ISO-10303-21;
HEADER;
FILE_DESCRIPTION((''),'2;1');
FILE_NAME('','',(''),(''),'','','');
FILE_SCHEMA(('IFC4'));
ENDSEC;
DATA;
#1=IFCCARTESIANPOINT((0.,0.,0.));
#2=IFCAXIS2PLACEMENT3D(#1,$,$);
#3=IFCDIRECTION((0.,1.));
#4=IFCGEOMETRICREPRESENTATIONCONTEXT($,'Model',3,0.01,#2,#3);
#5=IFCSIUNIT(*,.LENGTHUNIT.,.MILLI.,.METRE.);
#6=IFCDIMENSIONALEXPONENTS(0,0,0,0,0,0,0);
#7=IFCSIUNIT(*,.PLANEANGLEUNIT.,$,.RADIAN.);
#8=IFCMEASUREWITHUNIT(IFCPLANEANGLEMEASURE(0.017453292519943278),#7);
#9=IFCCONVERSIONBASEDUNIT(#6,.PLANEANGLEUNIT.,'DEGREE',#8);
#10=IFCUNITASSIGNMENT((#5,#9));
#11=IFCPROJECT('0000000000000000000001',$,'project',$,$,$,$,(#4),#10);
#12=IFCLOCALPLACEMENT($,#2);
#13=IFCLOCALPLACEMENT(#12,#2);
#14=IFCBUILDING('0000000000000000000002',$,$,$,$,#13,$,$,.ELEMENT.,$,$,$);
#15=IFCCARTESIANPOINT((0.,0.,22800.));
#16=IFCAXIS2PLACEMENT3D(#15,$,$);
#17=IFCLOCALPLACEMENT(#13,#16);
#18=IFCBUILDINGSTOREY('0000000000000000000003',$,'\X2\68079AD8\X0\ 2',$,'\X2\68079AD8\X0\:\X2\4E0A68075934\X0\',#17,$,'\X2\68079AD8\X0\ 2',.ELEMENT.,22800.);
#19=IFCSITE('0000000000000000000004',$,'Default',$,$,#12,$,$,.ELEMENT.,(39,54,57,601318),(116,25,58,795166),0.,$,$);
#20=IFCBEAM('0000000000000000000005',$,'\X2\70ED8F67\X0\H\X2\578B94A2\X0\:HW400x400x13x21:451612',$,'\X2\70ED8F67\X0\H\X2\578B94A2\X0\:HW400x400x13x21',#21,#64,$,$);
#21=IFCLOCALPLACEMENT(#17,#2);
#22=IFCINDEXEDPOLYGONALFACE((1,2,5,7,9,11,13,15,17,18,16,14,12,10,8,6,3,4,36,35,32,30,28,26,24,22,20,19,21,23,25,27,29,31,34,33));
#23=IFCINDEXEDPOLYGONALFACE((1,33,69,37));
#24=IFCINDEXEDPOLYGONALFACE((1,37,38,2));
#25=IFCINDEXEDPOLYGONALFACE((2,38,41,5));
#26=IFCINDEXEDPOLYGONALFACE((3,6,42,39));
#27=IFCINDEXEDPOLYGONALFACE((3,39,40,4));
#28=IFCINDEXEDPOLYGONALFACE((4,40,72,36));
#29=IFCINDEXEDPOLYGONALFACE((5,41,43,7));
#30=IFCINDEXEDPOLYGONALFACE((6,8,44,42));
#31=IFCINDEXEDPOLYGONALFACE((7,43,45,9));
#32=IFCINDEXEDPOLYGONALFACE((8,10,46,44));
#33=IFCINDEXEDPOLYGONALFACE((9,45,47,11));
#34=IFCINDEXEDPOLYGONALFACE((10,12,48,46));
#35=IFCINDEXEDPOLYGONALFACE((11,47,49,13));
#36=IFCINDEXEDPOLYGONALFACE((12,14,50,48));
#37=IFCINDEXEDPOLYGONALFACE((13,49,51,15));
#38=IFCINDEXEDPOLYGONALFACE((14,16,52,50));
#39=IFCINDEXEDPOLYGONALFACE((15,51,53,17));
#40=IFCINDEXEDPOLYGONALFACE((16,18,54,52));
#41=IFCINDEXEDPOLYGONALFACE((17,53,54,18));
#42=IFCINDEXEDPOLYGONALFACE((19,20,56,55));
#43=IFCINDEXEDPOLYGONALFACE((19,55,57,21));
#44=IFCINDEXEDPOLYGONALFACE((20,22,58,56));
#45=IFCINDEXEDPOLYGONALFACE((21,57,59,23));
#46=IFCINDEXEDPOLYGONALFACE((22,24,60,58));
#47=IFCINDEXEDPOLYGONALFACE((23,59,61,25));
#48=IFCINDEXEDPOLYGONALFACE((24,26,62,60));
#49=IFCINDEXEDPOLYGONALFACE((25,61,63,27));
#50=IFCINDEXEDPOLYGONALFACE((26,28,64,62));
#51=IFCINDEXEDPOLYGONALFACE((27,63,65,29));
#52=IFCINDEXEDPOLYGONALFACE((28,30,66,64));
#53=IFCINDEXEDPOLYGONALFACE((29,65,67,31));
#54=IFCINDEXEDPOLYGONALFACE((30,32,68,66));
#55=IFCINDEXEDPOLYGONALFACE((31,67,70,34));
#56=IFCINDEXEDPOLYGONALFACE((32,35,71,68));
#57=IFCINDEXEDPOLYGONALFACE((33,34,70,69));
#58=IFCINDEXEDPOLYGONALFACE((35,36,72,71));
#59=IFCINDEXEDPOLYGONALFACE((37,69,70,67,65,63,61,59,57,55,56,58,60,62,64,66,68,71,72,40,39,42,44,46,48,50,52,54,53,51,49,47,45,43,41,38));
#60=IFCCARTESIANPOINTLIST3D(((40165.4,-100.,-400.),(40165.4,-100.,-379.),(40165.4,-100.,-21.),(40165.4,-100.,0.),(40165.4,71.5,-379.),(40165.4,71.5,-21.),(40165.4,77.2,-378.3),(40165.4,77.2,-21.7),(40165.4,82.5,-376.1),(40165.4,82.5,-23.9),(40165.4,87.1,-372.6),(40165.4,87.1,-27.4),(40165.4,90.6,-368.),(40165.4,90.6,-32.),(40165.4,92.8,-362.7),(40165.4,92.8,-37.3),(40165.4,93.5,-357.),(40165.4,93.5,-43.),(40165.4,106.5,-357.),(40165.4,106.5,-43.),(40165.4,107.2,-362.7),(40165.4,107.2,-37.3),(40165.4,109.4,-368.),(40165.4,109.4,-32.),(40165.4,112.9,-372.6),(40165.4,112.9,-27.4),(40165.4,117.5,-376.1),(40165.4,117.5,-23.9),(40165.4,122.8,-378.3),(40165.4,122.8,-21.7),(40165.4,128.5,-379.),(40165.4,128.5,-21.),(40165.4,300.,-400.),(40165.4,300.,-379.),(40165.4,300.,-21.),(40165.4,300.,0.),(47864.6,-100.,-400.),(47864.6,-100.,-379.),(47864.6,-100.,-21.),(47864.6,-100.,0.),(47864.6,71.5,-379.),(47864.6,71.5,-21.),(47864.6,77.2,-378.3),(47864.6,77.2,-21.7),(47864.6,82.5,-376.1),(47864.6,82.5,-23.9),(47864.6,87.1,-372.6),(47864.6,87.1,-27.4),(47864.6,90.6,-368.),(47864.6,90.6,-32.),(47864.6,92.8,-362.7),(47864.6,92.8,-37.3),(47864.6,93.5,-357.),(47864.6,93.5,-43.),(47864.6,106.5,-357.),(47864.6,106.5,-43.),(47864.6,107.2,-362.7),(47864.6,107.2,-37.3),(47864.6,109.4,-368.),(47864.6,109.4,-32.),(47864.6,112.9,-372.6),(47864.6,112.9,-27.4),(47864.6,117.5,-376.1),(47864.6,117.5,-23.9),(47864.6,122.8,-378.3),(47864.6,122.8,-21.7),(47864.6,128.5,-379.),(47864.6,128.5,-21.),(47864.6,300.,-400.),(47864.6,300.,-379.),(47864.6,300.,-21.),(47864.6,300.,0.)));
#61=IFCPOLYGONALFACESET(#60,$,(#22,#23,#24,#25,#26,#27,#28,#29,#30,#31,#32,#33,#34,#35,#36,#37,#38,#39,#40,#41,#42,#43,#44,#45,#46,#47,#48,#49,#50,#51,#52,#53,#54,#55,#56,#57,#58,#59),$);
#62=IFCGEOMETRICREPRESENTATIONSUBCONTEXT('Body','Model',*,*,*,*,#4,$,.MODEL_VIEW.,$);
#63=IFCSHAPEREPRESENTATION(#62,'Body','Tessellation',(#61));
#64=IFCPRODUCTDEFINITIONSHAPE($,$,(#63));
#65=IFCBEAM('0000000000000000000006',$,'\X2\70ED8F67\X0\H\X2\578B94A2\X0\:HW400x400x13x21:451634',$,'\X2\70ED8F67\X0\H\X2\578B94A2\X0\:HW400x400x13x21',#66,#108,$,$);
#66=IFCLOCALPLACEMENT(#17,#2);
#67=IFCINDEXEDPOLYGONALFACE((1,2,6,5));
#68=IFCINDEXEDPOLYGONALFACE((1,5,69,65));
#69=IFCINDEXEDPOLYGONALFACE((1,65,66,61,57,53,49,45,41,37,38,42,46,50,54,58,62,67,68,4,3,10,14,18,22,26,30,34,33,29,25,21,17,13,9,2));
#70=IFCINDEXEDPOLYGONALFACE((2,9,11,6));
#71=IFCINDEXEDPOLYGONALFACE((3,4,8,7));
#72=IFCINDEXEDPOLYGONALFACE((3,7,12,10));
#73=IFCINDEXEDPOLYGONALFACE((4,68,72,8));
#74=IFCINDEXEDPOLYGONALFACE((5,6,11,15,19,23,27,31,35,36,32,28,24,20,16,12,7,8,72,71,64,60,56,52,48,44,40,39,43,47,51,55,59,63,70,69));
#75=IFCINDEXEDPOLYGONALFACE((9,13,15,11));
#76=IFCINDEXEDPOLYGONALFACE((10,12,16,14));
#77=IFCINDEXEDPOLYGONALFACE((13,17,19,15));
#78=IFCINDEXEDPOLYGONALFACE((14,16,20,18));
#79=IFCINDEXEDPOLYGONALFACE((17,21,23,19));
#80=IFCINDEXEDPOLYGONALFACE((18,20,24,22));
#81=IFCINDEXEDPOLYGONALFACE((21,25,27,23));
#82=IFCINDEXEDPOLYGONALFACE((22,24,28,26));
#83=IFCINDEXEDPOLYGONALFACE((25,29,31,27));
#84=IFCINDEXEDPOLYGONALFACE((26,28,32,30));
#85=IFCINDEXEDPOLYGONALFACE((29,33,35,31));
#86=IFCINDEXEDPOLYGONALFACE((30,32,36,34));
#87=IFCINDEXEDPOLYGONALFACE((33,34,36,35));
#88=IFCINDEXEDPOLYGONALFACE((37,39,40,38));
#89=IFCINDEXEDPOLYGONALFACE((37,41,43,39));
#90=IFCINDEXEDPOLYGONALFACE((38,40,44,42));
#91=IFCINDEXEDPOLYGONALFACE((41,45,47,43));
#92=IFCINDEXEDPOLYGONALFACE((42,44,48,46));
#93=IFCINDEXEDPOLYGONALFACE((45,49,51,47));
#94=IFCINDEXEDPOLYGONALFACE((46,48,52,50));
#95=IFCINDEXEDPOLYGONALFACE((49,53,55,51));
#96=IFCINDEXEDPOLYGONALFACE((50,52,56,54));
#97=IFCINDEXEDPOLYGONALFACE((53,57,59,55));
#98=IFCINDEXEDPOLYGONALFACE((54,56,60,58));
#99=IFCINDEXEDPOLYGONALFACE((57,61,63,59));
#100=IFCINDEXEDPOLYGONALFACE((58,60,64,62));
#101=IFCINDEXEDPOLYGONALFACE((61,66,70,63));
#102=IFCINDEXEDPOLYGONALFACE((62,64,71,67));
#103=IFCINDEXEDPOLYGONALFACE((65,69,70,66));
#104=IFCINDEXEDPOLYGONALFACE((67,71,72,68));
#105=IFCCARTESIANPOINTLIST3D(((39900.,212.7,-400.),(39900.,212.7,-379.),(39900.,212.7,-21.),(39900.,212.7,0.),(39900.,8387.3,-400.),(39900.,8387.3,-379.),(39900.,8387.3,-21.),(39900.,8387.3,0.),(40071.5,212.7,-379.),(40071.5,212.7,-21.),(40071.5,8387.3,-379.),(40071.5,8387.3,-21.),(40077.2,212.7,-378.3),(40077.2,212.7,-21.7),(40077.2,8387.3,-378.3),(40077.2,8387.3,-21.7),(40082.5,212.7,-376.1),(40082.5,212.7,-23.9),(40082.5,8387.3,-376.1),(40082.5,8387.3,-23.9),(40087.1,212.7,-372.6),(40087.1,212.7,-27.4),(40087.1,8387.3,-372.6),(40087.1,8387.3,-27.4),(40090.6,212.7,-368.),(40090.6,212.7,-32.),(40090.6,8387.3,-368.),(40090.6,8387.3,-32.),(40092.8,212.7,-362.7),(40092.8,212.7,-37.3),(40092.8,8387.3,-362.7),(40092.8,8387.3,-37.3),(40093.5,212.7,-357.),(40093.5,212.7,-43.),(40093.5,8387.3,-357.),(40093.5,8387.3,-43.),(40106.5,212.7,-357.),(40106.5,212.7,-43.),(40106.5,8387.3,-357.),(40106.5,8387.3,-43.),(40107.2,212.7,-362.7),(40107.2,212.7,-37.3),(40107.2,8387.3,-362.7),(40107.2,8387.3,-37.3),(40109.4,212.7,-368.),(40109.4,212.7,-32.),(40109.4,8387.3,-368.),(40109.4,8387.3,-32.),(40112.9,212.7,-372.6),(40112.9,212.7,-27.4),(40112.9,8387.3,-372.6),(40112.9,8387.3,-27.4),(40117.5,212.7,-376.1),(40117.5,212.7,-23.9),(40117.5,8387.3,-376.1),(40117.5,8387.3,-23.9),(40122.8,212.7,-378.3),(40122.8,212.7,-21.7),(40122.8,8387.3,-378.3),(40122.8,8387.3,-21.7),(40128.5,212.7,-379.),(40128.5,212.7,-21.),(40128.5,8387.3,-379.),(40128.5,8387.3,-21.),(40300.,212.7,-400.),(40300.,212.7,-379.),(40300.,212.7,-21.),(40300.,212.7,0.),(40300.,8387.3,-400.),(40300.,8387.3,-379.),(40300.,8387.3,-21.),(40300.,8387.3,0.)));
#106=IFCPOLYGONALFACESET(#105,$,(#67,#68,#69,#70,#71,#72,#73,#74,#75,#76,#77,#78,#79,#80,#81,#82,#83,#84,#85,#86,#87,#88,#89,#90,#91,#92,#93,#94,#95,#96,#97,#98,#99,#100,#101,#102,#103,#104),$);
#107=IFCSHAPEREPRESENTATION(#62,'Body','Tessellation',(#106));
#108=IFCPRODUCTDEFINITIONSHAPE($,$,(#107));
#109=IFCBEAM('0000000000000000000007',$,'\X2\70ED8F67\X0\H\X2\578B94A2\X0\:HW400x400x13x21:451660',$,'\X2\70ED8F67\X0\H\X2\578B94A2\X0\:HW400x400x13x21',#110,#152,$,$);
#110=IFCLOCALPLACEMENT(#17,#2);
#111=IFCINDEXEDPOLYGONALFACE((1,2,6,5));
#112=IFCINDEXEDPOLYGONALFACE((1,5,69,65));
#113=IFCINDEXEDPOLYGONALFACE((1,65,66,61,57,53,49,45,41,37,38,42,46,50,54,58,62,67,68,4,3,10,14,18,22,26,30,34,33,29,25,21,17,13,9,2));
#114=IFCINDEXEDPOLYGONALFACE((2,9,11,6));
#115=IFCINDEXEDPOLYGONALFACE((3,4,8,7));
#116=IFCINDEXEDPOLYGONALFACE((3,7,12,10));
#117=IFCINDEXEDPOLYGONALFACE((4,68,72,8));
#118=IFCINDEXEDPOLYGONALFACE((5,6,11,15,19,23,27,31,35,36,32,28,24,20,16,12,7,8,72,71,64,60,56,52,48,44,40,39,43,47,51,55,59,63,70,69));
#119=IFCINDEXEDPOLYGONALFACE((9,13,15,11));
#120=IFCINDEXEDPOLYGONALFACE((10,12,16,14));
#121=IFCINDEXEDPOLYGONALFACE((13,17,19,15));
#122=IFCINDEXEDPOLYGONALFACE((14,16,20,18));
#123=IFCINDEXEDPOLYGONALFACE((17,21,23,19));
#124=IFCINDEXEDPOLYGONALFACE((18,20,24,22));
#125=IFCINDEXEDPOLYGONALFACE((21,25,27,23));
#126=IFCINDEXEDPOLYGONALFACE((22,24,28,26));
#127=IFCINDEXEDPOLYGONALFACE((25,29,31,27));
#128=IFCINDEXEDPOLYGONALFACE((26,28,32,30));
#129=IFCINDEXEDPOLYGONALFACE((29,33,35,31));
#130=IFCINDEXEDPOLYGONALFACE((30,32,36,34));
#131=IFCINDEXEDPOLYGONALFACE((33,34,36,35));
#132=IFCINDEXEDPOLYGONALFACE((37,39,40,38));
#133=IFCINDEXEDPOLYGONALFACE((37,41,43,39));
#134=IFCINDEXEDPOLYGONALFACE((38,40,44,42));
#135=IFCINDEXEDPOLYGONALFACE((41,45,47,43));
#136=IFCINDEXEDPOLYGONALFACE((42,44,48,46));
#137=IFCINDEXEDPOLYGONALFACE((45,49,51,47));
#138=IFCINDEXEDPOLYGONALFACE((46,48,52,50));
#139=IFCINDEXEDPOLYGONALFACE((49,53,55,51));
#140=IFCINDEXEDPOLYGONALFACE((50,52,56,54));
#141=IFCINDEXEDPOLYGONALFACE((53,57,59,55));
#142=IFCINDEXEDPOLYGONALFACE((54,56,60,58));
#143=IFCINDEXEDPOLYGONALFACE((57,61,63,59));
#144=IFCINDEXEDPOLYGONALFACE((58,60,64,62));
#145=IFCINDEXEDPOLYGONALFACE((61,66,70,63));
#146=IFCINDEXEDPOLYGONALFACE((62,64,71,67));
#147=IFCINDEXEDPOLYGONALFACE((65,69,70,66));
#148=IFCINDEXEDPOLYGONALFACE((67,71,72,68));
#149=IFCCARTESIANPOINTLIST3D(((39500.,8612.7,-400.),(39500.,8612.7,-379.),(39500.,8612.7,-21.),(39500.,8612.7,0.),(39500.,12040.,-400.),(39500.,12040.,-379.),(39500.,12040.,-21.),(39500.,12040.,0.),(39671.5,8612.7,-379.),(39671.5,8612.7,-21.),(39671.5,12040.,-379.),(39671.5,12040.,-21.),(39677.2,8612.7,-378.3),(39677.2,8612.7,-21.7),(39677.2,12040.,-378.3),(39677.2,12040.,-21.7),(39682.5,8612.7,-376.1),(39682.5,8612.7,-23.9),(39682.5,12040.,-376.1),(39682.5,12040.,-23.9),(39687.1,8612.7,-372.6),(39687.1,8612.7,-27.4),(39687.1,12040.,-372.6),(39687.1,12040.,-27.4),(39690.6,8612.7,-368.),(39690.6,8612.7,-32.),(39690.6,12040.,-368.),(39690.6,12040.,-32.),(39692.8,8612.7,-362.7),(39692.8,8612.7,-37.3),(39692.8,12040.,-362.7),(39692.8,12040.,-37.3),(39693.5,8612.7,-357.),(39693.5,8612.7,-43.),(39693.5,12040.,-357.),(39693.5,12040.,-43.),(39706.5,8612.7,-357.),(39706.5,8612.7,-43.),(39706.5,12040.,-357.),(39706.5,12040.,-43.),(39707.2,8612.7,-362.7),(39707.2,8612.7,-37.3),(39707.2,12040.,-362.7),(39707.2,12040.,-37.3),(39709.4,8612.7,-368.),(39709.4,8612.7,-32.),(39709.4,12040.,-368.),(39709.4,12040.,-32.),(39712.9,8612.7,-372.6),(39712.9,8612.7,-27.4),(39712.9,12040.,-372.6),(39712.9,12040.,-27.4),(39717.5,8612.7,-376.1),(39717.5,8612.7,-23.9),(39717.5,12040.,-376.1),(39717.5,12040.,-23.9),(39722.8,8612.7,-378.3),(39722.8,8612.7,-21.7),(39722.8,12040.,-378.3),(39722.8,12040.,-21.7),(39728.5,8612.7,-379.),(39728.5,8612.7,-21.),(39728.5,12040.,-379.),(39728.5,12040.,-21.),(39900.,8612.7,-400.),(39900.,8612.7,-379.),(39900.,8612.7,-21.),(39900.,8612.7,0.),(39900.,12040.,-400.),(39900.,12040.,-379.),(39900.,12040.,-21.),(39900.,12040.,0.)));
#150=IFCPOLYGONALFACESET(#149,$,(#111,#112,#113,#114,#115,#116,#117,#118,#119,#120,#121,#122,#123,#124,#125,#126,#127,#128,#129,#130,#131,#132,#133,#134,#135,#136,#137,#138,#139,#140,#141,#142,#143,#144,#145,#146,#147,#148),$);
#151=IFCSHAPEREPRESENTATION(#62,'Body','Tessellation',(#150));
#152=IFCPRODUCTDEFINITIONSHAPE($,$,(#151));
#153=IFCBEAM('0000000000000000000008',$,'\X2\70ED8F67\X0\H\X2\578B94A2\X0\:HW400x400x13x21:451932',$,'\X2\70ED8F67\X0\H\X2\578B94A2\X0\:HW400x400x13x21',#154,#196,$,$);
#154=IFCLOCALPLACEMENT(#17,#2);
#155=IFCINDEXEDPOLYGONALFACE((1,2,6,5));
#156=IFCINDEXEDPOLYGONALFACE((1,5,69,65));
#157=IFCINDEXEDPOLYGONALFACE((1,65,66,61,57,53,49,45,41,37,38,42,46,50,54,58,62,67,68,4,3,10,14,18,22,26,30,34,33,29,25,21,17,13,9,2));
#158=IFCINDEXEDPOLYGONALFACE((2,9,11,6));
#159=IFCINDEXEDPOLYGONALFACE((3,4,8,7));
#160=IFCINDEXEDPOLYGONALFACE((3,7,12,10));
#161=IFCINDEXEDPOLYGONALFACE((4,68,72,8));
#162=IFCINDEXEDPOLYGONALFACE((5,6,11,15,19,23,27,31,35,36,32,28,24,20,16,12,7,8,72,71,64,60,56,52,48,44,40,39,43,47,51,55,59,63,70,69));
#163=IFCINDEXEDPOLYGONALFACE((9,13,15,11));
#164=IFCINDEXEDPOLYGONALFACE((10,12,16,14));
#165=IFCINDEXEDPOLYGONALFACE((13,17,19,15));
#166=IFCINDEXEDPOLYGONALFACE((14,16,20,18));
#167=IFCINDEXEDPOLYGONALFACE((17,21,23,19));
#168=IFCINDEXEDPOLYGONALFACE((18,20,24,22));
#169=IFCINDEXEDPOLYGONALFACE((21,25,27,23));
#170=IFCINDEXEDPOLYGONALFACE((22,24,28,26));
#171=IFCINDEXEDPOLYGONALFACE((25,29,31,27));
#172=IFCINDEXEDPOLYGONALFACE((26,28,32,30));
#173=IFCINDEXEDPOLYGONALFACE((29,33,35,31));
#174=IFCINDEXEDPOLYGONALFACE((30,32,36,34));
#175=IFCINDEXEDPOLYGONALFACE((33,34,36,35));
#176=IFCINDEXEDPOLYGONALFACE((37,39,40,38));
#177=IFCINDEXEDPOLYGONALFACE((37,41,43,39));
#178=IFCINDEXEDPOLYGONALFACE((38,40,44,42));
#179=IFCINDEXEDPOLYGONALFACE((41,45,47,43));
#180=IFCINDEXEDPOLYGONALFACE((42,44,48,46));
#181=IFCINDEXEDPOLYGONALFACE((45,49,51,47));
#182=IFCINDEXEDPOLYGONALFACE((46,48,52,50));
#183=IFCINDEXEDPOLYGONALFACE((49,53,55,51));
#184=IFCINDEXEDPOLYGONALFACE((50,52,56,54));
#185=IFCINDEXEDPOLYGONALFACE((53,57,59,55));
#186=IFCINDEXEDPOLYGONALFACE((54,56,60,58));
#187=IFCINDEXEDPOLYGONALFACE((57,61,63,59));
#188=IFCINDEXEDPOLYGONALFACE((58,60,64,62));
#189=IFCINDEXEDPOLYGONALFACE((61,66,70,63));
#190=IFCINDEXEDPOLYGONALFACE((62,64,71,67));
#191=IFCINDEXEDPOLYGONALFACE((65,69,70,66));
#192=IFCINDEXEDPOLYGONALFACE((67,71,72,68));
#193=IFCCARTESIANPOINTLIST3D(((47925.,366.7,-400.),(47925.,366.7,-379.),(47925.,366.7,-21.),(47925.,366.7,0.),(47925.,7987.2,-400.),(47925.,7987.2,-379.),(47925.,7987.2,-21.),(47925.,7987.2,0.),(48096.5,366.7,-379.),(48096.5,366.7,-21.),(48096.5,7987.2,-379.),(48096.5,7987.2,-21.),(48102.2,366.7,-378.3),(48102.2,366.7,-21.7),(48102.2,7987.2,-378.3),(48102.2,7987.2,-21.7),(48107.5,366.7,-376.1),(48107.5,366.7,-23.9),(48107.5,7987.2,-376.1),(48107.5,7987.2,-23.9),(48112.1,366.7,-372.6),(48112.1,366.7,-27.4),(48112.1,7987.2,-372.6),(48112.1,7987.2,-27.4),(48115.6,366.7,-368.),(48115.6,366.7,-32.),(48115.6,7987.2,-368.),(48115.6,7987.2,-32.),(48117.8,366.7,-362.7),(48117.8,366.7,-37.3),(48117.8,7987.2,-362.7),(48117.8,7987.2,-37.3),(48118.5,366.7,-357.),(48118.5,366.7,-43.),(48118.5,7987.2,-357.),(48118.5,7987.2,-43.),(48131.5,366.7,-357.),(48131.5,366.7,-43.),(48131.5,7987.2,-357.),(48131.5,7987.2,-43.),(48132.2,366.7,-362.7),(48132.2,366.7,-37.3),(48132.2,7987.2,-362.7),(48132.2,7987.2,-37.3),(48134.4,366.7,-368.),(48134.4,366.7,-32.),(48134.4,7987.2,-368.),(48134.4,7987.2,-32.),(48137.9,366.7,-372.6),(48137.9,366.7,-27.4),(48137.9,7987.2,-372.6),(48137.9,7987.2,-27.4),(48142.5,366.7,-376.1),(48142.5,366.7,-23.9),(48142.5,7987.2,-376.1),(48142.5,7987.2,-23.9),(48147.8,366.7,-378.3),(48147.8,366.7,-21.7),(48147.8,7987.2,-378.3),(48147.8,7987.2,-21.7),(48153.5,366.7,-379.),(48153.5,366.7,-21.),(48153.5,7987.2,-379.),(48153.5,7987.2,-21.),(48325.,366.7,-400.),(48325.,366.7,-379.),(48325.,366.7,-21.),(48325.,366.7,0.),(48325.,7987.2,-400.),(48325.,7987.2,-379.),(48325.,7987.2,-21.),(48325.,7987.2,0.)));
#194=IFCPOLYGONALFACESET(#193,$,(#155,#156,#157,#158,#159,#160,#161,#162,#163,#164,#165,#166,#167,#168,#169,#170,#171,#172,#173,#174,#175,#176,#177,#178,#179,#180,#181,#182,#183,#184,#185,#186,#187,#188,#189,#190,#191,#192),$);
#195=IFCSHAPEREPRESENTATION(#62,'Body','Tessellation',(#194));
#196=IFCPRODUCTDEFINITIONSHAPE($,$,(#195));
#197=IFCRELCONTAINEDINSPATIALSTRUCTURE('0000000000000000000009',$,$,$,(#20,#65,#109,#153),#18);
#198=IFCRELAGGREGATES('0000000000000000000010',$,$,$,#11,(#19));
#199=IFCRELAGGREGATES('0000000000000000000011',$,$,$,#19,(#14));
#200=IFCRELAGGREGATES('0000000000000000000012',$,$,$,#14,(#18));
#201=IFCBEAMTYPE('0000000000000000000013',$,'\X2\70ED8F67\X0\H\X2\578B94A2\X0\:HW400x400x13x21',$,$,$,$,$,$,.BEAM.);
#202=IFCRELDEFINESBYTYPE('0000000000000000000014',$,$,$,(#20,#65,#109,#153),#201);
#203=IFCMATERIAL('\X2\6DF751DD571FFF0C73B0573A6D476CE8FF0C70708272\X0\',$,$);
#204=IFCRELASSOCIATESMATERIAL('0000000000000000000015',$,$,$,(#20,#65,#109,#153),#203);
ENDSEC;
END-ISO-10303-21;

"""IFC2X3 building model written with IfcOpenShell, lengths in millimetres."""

from ifc_helpers import new_model, entity, si_unit, converted_unit, direction, frame, frame_2d, origin, place, context, subcontext, project, spatial, i_section, extrude, material, type_object, element, save


model = new_model("IFC2X3")

# Units and contexts
model_context = context("Model", 3, precision=0.01, world=origin(), true_north=direction((0.0, 1.0)))
body_context = subcontext(model_context, "Body", "Model", "MODEL_VIEW")
ifc_project = project(units=[si_unit("LENGTHUNIT", "METRE", prefix="MILLI"), converted_unit("PLANEANGLEUNIT", "DEGREE", entity("IfcPlaneAngleMeasure", 0.017453292519943278), si_unit("PLANEANGLEUNIT", "RADIAN"), dimensions=[0, 0, 0, 0, 0, 0, 0])], contexts=[model_context])

# Site, building, storey
site_placement = place(None, origin())
site = spatial("IfcSite", under=ifc_project, at=site_placement, Name="Default", CompositionType="ELEMENT", RefLatitude=(39, 54, 57, 601318), RefLongitude=(116, 25, 58, 795166), RefElevation=0.0)
building_placement = place(site_placement, origin())
building = spatial("IfcBuilding", under=site, at=building_placement, CompositionType="ELEMENT")
storey_placement = place(building_placement, frame((0.0, 0.0, 22800.0)))
storey = spatial("IfcBuildingStorey", under=building, at=storey_placement, Name="标高 2", ObjectType="标高:上标头", LongName="标高 2", CompositionType="ELEMENT", Elevation=22800.0)

# Beams
ifc_material = material(Name="混凝土，现场浇注，灰色")
beam_type = type_object("IfcBeamType", Name="热轧H型钢:HW400x400x13x21", PredefinedType="BEAM")
beam_1_placement = place(storey_placement, frame((48125.0, 100.0, 0.0), z_axis=(0.0, 0.0, 1.0), x_axis=(-1.0, 0.0, 0.0)))
element("IfcBeam", 1, at=beam_1_placement, inside=storey, type_object=beam_type, material=ifc_material, Name="热轧H型钢:HW400x400x13x21:451612", ObjectType="热轧H型钢:HW400x400x13x21", context=body_context, shape_type="SweptSolid", body=[
    extrude(i_section(OverallWidth=400.0, OverallDepth=400.0, WebThickness=13.0, FlangeThickness=21.0, FilletRadius=22.0, at=frame_2d((0.0, 0.0), x_axis=(0.0, 1.0))), frame((260.4, 0.0, -200.0), z_axis=(1.0, 0.0, 0.0), x_axis=(0.0, 0.0, -1.0)), (0.0, 0.0, 1.0), 7699.2),
])
beam_2_placement = place(storey_placement, frame((40100.0, 0.0, 0.0), z_axis=(0.0, 0.0, 1.0), x_axis=(0.0, 1.0, 0.0)))
element("IfcBeam", 2, at=beam_2_placement, inside=storey, type_object=beam_type, material=ifc_material, Name="热轧H型钢:HW400x400x13x21:451634", ObjectType="热轧H型钢:HW400x400x13x21", context=body_context, shape_type="SweptSolid", body=[
    extrude(i_section(OverallWidth=400.0, OverallDepth=400.0, WebThickness=13.0, FlangeThickness=21.0, FilletRadius=22.0, at=frame_2d((0.0, 0.0), x_axis=(0.0, 1.0))), frame((212.7, 0.0, -200.0), z_axis=(1.0, 0.0, 0.0), x_axis=(0.0, 0.0, -1.0)), (0.0, 0.0, 1.0), 8174.6),
])
beam_3_placement = place(storey_placement, frame((39700.0, 11840.0, 0.0), z_axis=(0.0, 0.0, 1.0), x_axis=(0.0, -1.0, 0.0)))
element("IfcBeam", 3, at=beam_3_placement, inside=storey, type_object=beam_type, material=ifc_material, Name="热轧H型钢:HW400x400x13x21:451660", ObjectType="热轧H型钢:HW400x400x13x21", context=body_context, shape_type="SweptSolid", body=[
    extrude(i_section(OverallWidth=400.0, OverallDepth=400.0, WebThickness=13.0, FlangeThickness=21.0, FilletRadius=22.0, at=frame_2d((0.0, 0.0), x_axis=(0.0, 1.0))), frame((-200.0, 0.0, -200.0), z_axis=(1.0, 0.0, 0.0), x_axis=(0.0, 0.0, -1.0)), (0.0, 0.0, 1.0), 3427.3),
])
beam_4_placement = place(storey_placement, frame((48125.0, 8000.0, 0.0), z_axis=(0.0, 0.0, 1.0), x_axis=(0.0, -1.0, 0.0)))
element("IfcBeam", 4, at=beam_4_placement, inside=storey, type_object=beam_type, material=ifc_material, Name="热轧H型钢:HW400x400x13x21:451932", ObjectType="热轧H型钢:HW400x400x13x21", context=body_context, shape_type="SweptSolid", body=[
    extrude(i_section(OverallWidth=400.0, OverallDepth=400.0, WebThickness=13.0, FlangeThickness=21.0, FilletRadius=22.0, at=frame_2d((0.0, 0.0), x_axis=(0.0, 1.0))), frame((12.8, 0.0, -200.0), z_axis=(1.0, 0.0, 0.0), x_axis=(0.0, 0.0, -1.0)), (0.0, 0.0, 1.0), 7620.5),
])

save(model, "model.ifc")
